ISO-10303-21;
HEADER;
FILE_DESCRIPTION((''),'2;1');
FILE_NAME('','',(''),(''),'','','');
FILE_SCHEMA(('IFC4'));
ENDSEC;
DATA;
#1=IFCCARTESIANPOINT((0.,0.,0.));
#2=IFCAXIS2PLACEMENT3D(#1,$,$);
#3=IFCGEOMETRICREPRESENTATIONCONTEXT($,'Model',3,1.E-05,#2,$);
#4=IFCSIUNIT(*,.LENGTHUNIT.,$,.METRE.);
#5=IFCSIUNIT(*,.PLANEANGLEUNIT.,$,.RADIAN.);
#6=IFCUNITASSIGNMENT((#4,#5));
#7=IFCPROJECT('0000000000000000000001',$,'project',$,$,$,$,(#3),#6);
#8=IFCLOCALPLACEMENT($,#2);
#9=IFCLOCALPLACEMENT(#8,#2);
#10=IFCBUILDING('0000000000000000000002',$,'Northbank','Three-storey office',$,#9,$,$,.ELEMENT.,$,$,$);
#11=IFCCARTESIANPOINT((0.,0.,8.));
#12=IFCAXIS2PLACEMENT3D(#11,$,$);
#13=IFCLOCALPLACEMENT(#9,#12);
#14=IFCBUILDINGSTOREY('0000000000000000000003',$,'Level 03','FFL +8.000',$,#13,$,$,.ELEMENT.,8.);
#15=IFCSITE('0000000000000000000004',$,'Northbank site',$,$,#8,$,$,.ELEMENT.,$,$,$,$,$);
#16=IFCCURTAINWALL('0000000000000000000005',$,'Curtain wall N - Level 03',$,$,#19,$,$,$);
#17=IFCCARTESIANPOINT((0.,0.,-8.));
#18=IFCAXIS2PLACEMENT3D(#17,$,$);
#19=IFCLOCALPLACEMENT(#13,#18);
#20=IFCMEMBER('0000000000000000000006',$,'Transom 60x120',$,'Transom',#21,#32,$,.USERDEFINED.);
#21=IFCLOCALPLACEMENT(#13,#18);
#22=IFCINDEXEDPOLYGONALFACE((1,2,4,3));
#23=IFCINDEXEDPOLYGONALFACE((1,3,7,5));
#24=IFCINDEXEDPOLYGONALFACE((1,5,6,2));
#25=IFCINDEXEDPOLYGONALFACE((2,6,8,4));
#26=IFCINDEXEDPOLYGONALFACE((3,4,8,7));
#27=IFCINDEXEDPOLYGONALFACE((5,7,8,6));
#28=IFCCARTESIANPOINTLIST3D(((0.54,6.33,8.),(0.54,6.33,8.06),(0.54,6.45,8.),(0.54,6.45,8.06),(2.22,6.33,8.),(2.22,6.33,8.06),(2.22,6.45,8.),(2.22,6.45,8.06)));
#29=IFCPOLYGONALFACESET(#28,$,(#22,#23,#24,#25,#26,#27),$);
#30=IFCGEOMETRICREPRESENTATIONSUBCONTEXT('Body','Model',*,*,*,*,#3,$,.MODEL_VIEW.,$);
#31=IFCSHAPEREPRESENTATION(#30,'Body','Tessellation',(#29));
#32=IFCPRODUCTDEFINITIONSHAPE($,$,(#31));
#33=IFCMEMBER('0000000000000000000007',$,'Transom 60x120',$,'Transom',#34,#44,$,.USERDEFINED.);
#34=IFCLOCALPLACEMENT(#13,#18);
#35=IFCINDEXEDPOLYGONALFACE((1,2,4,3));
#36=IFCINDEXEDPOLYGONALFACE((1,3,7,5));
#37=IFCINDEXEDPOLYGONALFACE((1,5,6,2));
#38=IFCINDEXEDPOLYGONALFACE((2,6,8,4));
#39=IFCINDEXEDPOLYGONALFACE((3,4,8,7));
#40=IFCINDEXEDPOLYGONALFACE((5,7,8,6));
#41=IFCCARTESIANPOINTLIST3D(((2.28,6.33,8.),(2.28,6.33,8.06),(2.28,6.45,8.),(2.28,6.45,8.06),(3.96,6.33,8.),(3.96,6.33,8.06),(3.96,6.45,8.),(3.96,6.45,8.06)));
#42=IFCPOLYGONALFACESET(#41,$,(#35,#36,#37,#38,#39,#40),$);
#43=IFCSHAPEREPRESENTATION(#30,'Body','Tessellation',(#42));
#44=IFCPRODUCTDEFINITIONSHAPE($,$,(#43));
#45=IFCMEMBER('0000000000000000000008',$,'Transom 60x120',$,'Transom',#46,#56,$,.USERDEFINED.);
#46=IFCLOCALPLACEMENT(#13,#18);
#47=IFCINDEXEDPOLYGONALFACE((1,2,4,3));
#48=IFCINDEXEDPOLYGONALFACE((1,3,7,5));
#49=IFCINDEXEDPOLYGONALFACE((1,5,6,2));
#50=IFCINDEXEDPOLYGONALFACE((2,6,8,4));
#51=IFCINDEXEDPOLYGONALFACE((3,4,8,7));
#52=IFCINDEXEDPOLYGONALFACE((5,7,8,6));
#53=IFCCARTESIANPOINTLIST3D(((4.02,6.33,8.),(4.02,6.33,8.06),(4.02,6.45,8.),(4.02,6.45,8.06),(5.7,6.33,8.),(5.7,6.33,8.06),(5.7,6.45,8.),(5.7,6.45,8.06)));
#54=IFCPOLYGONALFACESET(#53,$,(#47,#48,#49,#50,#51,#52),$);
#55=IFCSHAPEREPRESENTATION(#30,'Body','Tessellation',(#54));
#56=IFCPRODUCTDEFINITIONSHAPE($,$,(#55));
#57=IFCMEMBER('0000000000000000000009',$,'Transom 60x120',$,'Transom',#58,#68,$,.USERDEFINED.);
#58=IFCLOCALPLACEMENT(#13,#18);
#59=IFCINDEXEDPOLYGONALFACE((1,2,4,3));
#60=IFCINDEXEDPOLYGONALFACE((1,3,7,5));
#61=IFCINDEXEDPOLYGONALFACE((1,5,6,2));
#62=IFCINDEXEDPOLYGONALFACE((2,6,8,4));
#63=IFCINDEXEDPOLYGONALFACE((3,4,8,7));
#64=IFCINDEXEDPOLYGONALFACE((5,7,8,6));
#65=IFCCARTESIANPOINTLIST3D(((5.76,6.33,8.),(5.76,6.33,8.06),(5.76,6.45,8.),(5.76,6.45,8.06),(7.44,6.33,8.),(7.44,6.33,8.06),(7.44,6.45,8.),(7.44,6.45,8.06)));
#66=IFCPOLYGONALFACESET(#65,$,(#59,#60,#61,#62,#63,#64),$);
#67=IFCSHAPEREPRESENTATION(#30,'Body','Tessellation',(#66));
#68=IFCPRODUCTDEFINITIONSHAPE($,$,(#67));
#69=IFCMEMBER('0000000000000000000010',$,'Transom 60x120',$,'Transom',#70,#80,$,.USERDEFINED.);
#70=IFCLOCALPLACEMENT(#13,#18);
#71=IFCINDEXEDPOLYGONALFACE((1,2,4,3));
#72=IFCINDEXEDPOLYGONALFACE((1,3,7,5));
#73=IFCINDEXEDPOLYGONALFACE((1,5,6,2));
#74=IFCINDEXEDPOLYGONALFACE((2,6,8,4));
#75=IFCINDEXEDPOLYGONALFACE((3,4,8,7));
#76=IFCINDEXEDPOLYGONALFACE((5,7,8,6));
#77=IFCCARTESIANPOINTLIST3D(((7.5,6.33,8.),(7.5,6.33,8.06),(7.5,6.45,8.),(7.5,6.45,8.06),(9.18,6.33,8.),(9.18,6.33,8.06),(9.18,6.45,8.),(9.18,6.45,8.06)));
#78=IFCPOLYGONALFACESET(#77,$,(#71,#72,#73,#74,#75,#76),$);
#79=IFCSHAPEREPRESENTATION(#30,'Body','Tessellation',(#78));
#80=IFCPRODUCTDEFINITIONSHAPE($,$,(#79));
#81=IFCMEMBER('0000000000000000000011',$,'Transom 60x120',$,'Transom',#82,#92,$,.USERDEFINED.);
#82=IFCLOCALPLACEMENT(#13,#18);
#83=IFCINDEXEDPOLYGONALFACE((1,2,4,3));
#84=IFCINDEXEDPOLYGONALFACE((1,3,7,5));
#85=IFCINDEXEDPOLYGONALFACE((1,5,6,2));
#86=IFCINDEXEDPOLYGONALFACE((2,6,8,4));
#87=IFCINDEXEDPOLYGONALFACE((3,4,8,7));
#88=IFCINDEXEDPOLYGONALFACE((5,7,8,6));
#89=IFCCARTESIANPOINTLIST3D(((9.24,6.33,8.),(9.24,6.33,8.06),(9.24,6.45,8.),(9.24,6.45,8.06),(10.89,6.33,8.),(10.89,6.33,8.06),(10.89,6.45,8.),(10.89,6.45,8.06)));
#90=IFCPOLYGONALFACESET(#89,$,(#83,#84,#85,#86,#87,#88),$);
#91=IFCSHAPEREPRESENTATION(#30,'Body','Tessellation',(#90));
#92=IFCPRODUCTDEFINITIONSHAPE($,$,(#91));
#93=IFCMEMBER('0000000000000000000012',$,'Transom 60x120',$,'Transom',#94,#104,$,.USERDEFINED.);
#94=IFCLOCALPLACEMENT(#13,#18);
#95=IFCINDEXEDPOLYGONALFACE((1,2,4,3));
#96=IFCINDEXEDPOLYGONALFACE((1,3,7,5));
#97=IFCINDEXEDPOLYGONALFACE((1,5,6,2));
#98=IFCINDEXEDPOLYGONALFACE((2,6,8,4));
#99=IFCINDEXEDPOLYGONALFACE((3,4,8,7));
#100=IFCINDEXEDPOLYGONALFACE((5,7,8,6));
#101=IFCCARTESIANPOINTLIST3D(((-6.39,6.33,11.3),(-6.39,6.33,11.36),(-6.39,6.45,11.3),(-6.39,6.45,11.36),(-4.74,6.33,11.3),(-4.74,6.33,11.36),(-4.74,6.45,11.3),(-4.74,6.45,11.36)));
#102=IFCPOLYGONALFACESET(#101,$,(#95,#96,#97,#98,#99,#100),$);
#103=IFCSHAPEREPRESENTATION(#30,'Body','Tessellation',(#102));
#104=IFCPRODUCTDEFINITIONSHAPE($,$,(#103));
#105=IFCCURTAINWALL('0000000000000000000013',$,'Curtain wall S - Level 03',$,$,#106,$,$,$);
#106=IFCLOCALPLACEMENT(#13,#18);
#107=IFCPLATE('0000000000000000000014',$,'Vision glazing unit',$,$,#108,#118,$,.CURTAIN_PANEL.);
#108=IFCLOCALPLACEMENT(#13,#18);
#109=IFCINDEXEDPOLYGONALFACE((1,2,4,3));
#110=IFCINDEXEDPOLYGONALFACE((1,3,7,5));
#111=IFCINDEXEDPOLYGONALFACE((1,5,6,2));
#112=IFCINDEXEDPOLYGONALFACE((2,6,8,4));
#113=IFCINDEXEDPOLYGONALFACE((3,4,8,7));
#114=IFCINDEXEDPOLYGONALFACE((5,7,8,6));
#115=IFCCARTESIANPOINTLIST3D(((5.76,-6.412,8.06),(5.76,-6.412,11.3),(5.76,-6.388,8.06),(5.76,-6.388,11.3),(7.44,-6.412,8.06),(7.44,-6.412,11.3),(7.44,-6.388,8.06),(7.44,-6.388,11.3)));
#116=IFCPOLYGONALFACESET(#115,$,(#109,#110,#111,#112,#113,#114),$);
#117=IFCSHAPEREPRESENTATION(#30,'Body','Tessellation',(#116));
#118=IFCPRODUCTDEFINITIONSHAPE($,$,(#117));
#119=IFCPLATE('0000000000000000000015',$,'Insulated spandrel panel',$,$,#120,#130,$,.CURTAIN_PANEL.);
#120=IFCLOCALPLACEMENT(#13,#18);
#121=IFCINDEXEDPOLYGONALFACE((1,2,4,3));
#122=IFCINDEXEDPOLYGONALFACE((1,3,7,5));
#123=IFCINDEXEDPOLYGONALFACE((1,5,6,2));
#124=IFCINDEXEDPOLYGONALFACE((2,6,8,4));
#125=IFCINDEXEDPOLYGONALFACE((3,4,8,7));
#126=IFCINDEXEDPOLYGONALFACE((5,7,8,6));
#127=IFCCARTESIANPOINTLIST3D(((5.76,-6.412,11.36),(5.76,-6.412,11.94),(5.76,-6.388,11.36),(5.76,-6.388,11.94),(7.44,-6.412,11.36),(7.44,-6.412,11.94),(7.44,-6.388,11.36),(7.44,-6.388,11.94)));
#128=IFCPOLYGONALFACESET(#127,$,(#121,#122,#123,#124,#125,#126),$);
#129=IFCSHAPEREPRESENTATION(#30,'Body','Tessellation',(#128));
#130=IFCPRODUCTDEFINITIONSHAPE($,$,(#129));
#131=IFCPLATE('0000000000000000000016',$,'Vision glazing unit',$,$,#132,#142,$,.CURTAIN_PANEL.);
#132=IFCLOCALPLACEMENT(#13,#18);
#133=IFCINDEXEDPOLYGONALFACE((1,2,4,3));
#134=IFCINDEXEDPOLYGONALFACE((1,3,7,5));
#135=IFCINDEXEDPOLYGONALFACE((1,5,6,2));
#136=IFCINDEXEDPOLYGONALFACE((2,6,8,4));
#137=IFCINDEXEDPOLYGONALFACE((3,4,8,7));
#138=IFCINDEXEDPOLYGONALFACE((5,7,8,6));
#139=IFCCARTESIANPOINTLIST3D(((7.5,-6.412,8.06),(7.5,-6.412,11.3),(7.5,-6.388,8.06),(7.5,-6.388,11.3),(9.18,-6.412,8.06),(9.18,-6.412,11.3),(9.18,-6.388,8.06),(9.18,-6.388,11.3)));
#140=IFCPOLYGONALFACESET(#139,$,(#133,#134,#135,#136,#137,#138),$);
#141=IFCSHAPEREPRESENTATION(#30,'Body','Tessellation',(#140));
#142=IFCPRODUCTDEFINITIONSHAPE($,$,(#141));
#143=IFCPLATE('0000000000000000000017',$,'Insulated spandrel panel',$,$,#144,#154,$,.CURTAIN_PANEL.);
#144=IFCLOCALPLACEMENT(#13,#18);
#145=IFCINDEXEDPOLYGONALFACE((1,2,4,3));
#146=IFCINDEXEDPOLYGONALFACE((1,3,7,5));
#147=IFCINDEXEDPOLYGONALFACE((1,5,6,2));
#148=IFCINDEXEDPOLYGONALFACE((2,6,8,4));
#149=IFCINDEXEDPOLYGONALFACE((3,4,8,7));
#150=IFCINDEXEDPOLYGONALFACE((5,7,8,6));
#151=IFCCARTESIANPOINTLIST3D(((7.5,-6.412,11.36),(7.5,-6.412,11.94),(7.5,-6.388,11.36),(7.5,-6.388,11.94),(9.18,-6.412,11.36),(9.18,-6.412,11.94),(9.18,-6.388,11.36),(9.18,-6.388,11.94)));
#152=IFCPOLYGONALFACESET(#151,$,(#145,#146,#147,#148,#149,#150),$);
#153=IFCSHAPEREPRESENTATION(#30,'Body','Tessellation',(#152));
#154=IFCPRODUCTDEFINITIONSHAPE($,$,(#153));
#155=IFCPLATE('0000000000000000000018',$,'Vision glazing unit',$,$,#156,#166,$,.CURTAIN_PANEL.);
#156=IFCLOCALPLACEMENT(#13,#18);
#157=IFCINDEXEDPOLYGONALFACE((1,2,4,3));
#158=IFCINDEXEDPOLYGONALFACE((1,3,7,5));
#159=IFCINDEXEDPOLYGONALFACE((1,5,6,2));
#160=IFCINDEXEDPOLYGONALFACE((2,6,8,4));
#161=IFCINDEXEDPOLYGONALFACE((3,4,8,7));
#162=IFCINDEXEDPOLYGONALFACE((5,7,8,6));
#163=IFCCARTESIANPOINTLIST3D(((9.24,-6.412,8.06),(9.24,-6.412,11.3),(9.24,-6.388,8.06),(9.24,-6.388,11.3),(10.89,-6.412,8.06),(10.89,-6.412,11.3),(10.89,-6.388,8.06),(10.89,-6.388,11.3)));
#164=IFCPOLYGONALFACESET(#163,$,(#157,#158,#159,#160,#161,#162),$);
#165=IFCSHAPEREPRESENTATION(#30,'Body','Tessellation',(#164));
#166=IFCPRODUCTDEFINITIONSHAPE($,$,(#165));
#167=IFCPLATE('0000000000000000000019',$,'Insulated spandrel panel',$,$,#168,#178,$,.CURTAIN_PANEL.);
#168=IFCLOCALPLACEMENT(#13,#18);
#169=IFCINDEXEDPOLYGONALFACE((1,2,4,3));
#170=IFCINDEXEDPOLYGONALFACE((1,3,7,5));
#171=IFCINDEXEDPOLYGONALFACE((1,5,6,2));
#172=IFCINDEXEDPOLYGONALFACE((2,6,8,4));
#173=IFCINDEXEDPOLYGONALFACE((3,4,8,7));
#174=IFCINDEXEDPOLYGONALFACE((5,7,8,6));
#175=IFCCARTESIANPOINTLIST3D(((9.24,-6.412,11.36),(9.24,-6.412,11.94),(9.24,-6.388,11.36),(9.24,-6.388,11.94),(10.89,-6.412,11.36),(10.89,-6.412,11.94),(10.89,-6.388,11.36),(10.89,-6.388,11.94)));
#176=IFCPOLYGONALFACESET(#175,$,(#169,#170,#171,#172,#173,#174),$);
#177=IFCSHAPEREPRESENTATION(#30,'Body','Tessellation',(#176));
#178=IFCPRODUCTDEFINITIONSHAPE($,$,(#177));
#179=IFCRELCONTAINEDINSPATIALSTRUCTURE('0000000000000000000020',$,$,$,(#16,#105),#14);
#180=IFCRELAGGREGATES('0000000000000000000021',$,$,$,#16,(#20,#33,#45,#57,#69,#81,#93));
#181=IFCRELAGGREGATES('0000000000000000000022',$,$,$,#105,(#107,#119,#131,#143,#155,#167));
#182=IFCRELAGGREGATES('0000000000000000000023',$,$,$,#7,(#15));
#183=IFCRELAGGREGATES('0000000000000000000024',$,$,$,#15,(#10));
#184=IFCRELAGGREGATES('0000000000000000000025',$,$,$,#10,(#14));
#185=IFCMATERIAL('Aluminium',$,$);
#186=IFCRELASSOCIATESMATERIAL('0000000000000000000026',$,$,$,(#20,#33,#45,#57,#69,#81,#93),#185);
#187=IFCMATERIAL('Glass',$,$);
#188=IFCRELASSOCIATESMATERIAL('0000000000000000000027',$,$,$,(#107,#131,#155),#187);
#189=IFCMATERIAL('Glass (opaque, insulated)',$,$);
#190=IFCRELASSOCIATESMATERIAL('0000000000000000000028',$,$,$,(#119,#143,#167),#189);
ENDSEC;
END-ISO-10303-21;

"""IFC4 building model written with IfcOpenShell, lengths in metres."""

from ifc_helpers import new_model, si_unit, frame, origin, place, context, subcontext, project, spatial, rectangle, extrude, material, element, aggregate, save


model = new_model("IFC4")

# Units and contexts
model_context = context("Model", 3, precision=1e-05, world=origin())
body_context = subcontext(model_context, "Body", "Model", "MODEL_VIEW")
ifc_project = project(units=[si_unit("LENGTHUNIT", "METRE"), si_unit("PLANEANGLEUNIT", "RADIAN")], contexts=[model_context])

# Site, building, storey
site_placement = place(None, origin())
site = spatial("IfcSite", under=ifc_project, at=site_placement, Name="Northbank site", CompositionType="ELEMENT")
building_placement = place(site_placement, origin())
building = spatial("IfcBuilding", under=site, at=building_placement, Name="Northbank", Description="Three-storey office", CompositionType="ELEMENT")
storey_placement = place(building_placement, frame((0.0, 0.0, 8.0)))
storey = spatial("IfcBuildingStorey", under=building, at=storey_placement, Name="Level 03", Description="FFL +8.000", CompositionType="ELEMENT", Elevation=8.0)

# Curtain wall, members
curtain_wall_1_placement = place(storey_placement, frame((0.0, 0.0, -8.0)))
curtain_wall_1 = element("IfcCurtainWall", 1, at=curtain_wall_1_placement, inside=storey, Name="Curtain wall N - Level 03")
ifc_material_1 = material(Name="Aluminium")
member_1_placement = place(storey_placement, frame((0.0, 0.0, -8.0)))
member_1 = element("IfcMember", 2, at=member_1_placement, material=ifc_material_1, Name="Transom 60x120", ObjectType="Transom", PredefinedType="USERDEFINED", context=body_context, shape_type="SweptSolid", body=[
    extrude(rectangle(XDim=1.68, YDim=0.12), frame((1.38, 6.39, 8.0)), (0.0, 0.0, 1.0), 0.06),
])
member_2_placement = place(storey_placement, frame((0.0, 0.0, -8.0)))
member_2 = element("IfcMember", 3, at=member_2_placement, material=ifc_material_1, Name="Transom 60x120", ObjectType="Transom", PredefinedType="USERDEFINED", context=body_context, shape_type="SweptSolid", body=[
    extrude(rectangle(XDim=1.68, YDim=0.12), frame((3.12, 6.39, 8.0)), (0.0, 0.0, 1.0), 0.06),
])
member_3_placement = place(storey_placement, frame((0.0, 0.0, -8.0)))
member_3 = element("IfcMember", 4, at=member_3_placement, material=ifc_material_1, Name="Transom 60x120", ObjectType="Transom", PredefinedType="USERDEFINED", context=body_context, shape_type="SweptSolid", body=[
    extrude(rectangle(XDim=1.68, YDim=0.12), frame((4.86, 6.39, 8.0)), (0.0, 0.0, 1.0), 0.06),
])
member_4_placement = place(storey_placement, frame((0.0, 0.0, -8.0)))
member_4 = element("IfcMember", 5, at=member_4_placement, material=ifc_material_1, Name="Transom 60x120", ObjectType="Transom", PredefinedType="USERDEFINED", context=body_context, shape_type="SweptSolid", body=[
    extrude(rectangle(XDim=1.68, YDim=0.12), frame((6.6, 6.39, 8.0)), (0.0, 0.0, 1.0), 0.06),
])
member_5_placement = place(storey_placement, frame((0.0, 0.0, -8.0)))
member_5 = element("IfcMember", 6, at=member_5_placement, material=ifc_material_1, Name="Transom 60x120", ObjectType="Transom", PredefinedType="USERDEFINED", context=body_context, shape_type="SweptSolid", body=[
    extrude(rectangle(XDim=1.68, YDim=0.12), frame((8.34, 6.39, 8.0)), (0.0, 0.0, 1.0), 0.06),
])
member_6_placement = place(storey_placement, frame((0.0, 0.0, -8.0)))
member_6 = element("IfcMember", 7, at=member_6_placement, material=ifc_material_1, Name="Transom 60x120", ObjectType="Transom", PredefinedType="USERDEFINED", context=body_context, shape_type="SweptSolid", body=[
    extrude(rectangle(XDim=1.65, YDim=0.12), frame((10.065, 6.39, 8.0)), (0.0, 0.0, 1.0), 0.06),
])
member_7_placement = place(storey_placement, frame((0.0, 0.0, -8.0)))
member_7 = element("IfcMember", 8, at=member_7_placement, material=ifc_material_1, Name="Transom 60x120", ObjectType="Transom", PredefinedType="USERDEFINED", context=body_context, shape_type="SweptSolid", body=[
    extrude(rectangle(XDim=1.65, YDim=0.12), frame((-5.565, 6.39, 11.3)), (0.0, 0.0, 1.0), 0.06),
])
aggregate(curtain_wall_1, [member_1, member_2, member_3, member_4, member_5, member_6, member_7])

# Curtain wall, plates
curtain_wall_2_placement = place(storey_placement, frame((0.0, 0.0, -8.0)))
curtain_wall_2 = element("IfcCurtainWall", 9, at=curtain_wall_2_placement, inside=storey, Name="Curtain wall S - Level 03")
ifc_material_2 = material(Name="Glass")
plate_1_placement = place(storey_placement, frame((0.0, 0.0, -8.0)))
plate_1 = element("IfcPlate", 10, at=plate_1_placement, material=ifc_material_2, Name="Vision glazing unit", PredefinedType="CURTAIN_PANEL", context=body_context, shape_type="SweptSolid", body=[
    extrude(rectangle(XDim=1.68, YDim=0.024), frame((6.6, -6.4, 8.06)), (0.0, 0.0, 1.0), 3.24),
])
ifc_material_3 = material(Name="Glass (opaque, insulated)")
plate_2_placement = place(storey_placement, frame((0.0, 0.0, -8.0)))
plate_2 = element("IfcPlate", 11, at=plate_2_placement, material=ifc_material_3, Name="Insulated spandrel panel", PredefinedType="CURTAIN_PANEL", context=body_context, shape_type="SweptSolid", body=[
    extrude(rectangle(XDim=1.68, YDim=0.024), frame((6.6, -6.4, 11.36)), (0.0, 0.0, 1.0), 0.58),
])
plate_3_placement = place(storey_placement, frame((0.0, 0.0, -8.0)))
plate_3 = element("IfcPlate", 12, at=plate_3_placement, material=ifc_material_2, Name="Vision glazing unit", PredefinedType="CURTAIN_PANEL", context=body_context, shape_type="SweptSolid", body=[
    extrude(rectangle(XDim=1.68, YDim=0.024), frame((8.34, -6.4, 8.06)), (0.0, 0.0, 1.0), 3.24),
])
plate_4_placement = place(storey_placement, frame((0.0, 0.0, -8.0)))
plate_4 = element("IfcPlate", 13, at=plate_4_placement, material=ifc_material_3, Name="Insulated spandrel panel", PredefinedType="CURTAIN_PANEL", context=body_context, shape_type="SweptSolid", body=[
    extrude(rectangle(XDim=1.68, YDim=0.024), frame((8.34, -6.4, 11.36)), (0.0, 0.0, 1.0), 0.58),
])
plate_5_placement = place(storey_placement, frame((0.0, 0.0, -8.0)))
plate_5 = element("IfcPlate", 14, at=plate_5_placement, material=ifc_material_2, Name="Vision glazing unit", PredefinedType="CURTAIN_PANEL", context=body_context, shape_type="SweptSolid", body=[
    extrude(rectangle(XDim=1.65, YDim=0.024), frame((10.065, -6.4, 8.06)), (0.0, 0.0, 1.0), 3.24),
])
plate_6_placement = place(storey_placement, frame((0.0, 0.0, -8.0)))
plate_6 = element("IfcPlate", 15, at=plate_6_placement, material=ifc_material_3, Name="Insulated spandrel panel", PredefinedType="CURTAIN_PANEL", context=body_context, shape_type="SweptSolid", body=[
    extrude(rectangle(XDim=1.65, YDim=0.024), frame((10.065, -6.4, 11.36)), (0.0, 0.0, 1.0), 0.58),
])
aggregate(curtain_wall_2, [plate_1, plate_2, plate_3, plate_4, plate_5, plate_6])

save(model, "model.ifc")
